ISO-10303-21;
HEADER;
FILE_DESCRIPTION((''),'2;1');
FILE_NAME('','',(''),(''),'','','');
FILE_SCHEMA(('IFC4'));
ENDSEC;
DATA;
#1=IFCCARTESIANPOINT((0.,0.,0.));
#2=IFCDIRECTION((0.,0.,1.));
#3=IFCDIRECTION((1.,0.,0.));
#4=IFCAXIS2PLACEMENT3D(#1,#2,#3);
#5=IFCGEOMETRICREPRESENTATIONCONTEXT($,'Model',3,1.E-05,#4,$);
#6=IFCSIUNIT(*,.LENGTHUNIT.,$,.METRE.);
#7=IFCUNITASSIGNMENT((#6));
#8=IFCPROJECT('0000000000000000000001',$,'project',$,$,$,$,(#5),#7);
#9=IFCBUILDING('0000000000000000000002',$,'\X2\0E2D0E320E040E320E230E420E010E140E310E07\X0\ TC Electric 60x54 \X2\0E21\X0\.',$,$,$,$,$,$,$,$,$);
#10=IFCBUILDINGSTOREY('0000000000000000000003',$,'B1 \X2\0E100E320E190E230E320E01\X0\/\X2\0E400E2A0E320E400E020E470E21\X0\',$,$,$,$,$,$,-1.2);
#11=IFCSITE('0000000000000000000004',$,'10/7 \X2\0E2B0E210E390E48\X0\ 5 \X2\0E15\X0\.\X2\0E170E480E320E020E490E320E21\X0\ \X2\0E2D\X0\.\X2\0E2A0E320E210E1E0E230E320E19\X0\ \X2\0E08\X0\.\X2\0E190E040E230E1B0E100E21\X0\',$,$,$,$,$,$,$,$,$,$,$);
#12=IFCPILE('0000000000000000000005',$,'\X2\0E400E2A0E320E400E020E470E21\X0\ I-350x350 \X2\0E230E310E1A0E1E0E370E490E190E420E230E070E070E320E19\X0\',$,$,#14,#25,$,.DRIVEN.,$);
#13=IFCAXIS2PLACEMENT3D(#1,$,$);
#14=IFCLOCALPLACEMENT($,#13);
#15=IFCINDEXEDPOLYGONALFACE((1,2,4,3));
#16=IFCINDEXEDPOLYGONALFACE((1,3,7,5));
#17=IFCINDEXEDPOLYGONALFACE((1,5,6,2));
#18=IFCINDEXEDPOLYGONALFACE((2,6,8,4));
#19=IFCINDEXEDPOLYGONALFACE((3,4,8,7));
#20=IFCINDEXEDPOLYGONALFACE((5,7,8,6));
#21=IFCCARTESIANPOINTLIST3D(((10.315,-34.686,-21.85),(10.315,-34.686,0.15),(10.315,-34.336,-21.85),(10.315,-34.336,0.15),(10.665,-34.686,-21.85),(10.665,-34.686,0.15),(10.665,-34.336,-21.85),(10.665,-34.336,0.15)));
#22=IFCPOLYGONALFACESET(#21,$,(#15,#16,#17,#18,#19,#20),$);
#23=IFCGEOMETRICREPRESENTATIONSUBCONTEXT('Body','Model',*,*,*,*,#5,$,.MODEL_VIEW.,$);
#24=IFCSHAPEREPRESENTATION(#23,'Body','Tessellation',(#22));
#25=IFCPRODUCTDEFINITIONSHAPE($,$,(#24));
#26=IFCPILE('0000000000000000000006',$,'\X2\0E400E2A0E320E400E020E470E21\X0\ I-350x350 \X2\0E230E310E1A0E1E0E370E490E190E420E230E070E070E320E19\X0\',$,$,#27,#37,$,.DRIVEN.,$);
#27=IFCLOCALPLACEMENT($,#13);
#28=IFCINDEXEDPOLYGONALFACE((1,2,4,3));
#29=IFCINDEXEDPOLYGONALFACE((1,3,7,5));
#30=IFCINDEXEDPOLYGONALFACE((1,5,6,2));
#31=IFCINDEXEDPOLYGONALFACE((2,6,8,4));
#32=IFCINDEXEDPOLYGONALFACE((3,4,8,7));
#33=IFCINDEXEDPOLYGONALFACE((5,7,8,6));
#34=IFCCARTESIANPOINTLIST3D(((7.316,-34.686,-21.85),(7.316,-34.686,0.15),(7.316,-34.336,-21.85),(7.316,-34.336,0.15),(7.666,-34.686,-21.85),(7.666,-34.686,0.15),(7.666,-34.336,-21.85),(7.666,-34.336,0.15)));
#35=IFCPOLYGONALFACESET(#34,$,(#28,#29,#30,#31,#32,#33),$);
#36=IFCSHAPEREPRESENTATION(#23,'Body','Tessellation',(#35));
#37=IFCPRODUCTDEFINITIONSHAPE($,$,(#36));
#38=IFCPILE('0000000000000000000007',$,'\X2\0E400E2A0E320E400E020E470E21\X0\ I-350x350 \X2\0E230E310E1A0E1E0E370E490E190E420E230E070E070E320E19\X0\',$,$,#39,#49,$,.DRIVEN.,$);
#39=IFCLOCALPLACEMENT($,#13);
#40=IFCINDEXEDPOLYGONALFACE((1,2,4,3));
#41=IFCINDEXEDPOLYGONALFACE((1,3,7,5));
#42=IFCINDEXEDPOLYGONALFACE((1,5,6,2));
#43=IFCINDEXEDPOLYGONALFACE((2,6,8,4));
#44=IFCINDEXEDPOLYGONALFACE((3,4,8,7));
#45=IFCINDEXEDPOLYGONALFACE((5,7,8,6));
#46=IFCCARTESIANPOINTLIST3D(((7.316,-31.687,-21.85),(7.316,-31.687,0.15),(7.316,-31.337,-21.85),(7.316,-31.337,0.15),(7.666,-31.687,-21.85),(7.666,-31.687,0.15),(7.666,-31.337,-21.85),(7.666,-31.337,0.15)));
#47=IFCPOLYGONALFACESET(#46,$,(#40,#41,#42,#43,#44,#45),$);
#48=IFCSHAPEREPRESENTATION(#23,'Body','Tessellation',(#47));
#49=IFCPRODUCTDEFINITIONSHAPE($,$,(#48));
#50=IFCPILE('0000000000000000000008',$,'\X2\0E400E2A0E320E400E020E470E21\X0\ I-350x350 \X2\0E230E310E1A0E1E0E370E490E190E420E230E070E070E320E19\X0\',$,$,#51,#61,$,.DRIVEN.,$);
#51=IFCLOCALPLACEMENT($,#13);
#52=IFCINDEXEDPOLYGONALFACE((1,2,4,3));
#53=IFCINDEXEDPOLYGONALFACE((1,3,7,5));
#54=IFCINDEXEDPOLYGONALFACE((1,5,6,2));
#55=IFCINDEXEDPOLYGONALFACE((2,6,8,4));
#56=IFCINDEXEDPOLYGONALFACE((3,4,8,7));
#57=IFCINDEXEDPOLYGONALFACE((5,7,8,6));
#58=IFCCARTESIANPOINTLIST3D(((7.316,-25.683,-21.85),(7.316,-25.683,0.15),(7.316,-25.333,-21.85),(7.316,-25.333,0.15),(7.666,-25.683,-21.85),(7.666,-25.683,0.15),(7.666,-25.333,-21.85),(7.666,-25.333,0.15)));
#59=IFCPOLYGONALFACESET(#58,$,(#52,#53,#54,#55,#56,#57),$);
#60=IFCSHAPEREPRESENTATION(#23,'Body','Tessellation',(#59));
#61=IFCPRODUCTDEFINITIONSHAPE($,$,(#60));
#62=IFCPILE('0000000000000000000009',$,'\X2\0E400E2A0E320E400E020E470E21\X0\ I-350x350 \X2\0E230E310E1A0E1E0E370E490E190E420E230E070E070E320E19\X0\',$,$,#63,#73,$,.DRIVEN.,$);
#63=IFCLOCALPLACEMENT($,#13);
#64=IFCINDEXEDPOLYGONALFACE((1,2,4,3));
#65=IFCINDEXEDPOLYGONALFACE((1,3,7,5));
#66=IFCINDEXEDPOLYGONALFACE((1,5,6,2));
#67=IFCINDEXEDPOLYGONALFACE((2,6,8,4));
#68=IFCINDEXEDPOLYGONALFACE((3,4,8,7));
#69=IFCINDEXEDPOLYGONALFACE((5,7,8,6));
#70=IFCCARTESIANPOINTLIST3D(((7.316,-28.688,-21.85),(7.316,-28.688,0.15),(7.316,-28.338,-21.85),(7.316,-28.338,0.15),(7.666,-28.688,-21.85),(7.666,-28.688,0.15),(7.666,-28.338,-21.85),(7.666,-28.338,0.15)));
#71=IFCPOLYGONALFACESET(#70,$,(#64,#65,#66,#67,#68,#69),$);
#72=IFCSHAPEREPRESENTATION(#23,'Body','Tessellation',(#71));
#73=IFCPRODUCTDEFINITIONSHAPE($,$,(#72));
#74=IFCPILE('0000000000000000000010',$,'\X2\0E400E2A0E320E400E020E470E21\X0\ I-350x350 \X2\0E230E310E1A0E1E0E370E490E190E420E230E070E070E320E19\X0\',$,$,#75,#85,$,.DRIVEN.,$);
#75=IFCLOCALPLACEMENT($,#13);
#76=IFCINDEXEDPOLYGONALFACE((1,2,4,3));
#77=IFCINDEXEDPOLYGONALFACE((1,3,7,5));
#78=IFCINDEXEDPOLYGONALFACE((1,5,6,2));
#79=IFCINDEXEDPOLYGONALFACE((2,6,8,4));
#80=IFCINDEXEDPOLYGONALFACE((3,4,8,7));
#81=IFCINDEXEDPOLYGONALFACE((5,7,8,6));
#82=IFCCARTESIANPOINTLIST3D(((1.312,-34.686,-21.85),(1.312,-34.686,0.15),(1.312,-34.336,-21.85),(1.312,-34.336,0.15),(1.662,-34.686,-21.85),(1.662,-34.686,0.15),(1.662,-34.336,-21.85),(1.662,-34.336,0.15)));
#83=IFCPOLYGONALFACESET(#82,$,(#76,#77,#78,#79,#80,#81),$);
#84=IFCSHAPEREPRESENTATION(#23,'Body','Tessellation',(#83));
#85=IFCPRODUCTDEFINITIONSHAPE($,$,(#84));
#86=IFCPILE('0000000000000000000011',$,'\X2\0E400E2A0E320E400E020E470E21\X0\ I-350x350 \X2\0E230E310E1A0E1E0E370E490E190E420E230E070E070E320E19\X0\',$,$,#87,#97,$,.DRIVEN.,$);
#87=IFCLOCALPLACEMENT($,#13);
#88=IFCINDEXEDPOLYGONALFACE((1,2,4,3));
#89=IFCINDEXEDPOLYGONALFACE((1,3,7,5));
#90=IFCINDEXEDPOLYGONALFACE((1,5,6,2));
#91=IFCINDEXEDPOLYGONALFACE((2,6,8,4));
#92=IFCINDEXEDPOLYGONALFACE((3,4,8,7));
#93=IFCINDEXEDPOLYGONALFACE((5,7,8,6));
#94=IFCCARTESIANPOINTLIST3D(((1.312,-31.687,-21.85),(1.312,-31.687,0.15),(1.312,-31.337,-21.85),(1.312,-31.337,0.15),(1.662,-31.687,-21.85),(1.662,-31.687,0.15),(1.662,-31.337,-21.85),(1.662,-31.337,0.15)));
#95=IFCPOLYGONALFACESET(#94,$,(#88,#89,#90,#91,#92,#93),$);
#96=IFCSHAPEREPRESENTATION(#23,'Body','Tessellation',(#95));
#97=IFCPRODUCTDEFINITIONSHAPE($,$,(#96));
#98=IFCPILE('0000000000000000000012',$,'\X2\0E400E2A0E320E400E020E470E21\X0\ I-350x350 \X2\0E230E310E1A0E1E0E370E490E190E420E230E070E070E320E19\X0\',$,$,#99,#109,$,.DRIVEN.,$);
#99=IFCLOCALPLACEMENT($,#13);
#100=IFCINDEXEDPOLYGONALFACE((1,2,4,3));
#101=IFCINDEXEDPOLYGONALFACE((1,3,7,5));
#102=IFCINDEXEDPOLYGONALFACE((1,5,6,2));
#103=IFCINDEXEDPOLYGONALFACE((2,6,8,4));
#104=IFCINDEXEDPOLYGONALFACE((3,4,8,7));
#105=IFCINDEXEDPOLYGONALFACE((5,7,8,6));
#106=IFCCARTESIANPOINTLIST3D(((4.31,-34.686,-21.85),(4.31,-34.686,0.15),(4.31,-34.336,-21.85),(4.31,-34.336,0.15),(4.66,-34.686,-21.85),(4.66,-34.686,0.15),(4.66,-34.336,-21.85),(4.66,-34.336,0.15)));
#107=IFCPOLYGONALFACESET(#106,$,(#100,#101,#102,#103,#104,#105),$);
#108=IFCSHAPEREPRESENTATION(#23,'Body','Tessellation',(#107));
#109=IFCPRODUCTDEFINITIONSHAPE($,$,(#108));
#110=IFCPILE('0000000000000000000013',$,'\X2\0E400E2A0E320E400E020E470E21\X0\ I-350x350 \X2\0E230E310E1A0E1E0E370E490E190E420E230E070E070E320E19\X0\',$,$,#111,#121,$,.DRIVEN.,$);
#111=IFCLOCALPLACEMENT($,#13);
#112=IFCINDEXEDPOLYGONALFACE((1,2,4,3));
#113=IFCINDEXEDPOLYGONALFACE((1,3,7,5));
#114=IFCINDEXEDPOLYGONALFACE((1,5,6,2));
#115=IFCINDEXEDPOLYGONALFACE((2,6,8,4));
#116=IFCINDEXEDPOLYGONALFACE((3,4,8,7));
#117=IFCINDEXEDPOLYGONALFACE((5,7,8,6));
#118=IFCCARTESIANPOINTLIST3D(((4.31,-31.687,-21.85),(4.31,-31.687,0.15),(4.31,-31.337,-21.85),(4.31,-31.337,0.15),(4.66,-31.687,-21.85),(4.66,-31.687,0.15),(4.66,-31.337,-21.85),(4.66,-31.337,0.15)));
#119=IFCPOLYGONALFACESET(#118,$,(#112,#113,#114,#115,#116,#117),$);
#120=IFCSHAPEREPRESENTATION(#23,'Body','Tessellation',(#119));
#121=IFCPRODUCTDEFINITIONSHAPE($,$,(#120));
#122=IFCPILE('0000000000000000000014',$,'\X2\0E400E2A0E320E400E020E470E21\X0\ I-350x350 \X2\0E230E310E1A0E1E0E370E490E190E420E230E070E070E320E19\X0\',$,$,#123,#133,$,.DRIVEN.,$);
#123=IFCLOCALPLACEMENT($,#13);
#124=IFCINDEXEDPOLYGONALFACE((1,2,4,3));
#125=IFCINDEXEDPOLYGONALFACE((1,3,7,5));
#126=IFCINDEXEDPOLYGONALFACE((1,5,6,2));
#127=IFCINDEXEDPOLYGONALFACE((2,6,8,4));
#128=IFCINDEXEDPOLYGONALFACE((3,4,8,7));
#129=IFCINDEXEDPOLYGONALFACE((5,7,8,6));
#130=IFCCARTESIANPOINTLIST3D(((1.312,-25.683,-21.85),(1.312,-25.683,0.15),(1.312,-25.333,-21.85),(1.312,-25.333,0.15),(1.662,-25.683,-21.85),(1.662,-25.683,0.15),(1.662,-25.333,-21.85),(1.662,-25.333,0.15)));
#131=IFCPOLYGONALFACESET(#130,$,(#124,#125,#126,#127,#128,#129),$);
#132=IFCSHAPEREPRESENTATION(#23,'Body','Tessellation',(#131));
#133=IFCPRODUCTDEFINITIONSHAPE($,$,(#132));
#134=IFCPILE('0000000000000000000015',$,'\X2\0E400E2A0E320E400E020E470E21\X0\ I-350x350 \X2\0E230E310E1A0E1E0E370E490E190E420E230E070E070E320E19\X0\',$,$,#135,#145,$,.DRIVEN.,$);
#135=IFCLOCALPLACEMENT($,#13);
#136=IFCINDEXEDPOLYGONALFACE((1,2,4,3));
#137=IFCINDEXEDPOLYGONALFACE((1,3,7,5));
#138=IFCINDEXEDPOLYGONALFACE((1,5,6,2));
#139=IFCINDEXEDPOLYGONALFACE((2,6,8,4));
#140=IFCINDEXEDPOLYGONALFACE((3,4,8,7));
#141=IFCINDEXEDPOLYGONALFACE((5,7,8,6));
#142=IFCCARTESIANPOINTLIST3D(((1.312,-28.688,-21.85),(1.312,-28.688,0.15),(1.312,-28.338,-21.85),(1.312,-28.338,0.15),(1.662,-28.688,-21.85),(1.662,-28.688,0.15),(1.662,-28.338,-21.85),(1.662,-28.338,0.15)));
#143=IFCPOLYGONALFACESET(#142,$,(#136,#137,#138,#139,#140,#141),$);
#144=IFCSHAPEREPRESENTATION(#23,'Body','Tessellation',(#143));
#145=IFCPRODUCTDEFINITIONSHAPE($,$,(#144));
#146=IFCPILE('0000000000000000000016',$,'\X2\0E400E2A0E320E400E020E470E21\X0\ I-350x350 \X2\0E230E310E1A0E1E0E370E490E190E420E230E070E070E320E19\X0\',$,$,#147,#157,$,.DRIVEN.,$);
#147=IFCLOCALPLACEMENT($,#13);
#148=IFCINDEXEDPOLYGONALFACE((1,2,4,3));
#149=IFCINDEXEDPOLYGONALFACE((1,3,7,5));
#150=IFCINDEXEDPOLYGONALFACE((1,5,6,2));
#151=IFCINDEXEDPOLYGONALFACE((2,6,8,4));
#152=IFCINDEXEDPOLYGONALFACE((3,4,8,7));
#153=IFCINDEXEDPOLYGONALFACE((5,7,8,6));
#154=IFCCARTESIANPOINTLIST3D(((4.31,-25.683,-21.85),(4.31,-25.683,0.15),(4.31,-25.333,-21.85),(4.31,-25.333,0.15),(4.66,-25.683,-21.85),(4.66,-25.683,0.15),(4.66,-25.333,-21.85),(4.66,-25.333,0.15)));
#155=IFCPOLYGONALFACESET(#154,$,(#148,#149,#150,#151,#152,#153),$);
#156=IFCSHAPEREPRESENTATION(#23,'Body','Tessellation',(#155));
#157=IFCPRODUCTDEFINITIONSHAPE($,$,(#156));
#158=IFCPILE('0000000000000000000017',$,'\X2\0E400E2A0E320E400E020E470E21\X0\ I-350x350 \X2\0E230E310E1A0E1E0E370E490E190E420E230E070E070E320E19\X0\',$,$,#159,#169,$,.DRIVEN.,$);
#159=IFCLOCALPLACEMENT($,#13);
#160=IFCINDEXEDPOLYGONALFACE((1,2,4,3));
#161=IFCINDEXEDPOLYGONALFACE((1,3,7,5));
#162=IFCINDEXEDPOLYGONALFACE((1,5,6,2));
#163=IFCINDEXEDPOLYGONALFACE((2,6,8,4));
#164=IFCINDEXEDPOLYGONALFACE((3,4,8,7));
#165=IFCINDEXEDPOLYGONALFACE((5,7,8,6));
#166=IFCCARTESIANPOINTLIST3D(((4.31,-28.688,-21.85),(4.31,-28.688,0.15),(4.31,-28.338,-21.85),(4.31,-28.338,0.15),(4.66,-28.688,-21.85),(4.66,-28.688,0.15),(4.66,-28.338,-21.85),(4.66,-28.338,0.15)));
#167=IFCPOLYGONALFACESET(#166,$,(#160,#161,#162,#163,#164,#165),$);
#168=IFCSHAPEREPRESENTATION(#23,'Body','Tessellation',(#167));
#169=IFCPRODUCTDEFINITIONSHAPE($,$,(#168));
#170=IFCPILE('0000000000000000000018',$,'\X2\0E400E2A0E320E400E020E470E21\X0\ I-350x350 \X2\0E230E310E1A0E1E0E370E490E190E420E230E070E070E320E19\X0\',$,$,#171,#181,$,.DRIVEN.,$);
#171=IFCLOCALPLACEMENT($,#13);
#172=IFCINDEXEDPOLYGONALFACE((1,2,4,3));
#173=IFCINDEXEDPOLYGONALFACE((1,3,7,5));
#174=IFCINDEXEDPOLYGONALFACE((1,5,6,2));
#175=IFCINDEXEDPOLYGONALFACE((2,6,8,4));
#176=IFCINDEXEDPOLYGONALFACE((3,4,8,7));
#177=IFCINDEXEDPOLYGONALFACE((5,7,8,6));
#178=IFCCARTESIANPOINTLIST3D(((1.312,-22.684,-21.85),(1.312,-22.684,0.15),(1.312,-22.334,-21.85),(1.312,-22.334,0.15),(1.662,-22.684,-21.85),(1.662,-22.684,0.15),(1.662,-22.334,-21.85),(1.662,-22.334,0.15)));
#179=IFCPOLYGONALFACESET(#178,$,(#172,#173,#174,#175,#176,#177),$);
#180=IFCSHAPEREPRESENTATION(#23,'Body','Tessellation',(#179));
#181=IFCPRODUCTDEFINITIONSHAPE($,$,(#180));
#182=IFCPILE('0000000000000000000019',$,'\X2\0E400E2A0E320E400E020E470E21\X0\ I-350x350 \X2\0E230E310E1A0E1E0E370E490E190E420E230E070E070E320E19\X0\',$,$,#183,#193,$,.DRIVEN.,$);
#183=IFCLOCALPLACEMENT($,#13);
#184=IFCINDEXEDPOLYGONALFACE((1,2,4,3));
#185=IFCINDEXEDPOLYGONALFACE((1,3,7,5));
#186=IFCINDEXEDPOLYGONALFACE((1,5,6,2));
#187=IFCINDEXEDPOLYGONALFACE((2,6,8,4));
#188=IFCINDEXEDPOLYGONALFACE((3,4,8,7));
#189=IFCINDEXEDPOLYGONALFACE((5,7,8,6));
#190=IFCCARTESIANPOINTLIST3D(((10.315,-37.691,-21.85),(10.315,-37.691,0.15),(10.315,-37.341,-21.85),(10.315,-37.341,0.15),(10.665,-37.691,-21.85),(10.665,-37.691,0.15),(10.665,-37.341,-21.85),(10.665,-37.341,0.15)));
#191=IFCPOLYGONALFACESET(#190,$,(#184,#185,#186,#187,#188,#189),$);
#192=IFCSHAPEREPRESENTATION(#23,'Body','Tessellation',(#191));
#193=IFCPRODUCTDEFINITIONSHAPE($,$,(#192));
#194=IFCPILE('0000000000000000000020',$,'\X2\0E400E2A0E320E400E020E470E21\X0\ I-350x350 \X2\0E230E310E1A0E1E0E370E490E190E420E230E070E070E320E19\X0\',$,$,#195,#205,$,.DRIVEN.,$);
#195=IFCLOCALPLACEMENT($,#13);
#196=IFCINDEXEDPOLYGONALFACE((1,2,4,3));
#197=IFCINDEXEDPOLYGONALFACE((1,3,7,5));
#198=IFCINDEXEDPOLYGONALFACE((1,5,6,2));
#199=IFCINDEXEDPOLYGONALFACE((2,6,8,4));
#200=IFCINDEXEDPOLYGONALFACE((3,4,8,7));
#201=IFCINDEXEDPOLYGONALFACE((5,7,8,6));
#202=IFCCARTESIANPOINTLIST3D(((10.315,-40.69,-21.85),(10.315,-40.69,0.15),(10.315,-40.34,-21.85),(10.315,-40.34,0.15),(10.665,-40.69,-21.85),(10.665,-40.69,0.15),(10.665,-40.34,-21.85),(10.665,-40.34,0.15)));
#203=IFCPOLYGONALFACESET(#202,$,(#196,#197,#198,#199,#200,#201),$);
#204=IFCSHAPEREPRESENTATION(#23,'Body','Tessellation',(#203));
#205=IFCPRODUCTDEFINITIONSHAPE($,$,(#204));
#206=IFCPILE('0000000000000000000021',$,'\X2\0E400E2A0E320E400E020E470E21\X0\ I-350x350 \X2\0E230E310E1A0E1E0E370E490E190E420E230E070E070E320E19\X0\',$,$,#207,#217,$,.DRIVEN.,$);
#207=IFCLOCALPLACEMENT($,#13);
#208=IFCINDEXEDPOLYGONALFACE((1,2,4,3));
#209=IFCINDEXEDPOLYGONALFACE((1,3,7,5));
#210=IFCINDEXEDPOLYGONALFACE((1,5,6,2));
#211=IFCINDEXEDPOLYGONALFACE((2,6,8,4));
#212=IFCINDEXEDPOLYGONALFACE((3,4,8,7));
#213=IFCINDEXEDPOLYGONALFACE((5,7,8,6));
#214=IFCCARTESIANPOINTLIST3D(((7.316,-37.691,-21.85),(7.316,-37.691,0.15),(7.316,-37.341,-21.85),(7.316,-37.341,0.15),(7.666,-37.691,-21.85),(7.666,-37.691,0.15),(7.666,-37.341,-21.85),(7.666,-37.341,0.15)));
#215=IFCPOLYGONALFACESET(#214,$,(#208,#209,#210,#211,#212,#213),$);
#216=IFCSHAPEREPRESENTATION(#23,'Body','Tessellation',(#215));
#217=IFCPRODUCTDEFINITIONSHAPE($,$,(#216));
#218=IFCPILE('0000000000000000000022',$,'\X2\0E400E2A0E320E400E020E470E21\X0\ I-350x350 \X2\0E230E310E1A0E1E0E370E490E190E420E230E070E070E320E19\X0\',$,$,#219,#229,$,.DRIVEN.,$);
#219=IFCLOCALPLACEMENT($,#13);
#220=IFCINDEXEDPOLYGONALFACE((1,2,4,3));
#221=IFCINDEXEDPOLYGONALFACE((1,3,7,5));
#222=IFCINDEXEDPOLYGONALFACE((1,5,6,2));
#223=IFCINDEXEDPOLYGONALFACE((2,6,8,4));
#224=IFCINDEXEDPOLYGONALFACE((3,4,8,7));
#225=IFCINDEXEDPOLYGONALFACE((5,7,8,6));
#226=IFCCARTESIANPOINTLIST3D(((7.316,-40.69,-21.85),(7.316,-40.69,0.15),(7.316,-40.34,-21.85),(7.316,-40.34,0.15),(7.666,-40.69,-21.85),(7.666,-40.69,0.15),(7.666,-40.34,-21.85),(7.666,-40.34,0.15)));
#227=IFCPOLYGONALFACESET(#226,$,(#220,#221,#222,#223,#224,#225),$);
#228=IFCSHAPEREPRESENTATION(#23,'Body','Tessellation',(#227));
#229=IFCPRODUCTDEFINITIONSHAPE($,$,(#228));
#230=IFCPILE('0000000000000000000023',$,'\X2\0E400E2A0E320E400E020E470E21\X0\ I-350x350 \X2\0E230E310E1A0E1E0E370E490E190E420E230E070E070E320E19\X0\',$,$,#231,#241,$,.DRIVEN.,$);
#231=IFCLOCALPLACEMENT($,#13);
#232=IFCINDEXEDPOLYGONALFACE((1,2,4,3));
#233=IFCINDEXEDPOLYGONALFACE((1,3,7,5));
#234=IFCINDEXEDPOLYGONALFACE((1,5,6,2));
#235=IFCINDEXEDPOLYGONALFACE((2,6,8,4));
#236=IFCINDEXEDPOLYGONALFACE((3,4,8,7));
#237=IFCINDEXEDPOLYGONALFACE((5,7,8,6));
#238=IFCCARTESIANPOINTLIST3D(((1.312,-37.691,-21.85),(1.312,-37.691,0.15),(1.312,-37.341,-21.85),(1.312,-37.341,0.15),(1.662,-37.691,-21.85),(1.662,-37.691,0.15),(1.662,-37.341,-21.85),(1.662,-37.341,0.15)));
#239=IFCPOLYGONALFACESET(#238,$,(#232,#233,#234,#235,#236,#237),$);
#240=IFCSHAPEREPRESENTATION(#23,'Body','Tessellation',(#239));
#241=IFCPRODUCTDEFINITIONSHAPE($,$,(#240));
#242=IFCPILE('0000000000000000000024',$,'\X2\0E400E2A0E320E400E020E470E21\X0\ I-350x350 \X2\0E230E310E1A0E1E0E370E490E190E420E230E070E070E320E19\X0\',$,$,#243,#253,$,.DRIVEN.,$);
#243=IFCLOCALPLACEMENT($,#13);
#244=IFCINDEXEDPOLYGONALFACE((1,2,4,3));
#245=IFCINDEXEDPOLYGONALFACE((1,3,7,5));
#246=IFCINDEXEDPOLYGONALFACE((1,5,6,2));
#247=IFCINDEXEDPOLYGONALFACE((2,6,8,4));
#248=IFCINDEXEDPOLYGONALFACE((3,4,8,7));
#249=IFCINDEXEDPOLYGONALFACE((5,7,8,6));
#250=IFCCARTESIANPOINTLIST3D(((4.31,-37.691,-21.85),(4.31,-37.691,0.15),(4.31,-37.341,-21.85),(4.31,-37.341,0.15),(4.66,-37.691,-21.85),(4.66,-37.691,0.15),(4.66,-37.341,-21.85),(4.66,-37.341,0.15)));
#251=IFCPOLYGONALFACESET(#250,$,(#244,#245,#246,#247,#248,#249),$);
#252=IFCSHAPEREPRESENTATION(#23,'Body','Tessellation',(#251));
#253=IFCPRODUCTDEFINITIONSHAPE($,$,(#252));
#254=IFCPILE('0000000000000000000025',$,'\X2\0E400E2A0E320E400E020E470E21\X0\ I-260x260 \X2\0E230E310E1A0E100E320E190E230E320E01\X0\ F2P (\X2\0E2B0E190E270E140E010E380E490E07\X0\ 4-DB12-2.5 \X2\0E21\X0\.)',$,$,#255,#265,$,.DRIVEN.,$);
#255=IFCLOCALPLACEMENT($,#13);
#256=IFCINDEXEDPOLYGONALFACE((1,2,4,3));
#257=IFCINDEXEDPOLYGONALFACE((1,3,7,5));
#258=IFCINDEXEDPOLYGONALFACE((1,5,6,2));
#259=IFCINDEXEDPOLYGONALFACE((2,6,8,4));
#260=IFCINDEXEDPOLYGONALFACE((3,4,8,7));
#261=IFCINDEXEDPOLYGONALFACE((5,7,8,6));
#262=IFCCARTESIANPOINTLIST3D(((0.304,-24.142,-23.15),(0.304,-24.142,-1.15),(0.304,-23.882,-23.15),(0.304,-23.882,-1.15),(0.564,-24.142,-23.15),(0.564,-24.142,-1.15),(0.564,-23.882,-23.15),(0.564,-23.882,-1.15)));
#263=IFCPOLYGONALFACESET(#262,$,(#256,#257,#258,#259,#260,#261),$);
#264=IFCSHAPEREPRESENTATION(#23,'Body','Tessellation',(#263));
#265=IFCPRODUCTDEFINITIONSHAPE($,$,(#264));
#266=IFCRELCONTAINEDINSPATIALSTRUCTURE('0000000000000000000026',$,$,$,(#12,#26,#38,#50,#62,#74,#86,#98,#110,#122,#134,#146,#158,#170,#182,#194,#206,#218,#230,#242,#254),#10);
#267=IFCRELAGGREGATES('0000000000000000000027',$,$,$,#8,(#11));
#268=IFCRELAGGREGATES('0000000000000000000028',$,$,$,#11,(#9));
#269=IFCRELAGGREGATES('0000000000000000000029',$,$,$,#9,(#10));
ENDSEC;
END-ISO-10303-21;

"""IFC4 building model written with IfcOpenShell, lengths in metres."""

from ifc_helpers import new_model, si_unit, frame, origin, origin_with_axes, origin_2d, place, context, subcontext, project, spatial, rectangle, extrude, element, save


model = new_model("IFC4")

# Units and contexts
model_context = context("Model", 3, precision=1e-05, world=origin_with_axes())
body_context = subcontext(model_context, "Body", "Model", "MODEL_VIEW")
ifc_project = project(units=[si_unit("LENGTHUNIT", "METRE")], contexts=[model_context])

# Site, building, storey
site = spatial("IfcSite", under=ifc_project, Name="10/7 หมู่ 5 ต.ท่าข้าม อ.สามพราน จ.นครปฐม")
building = spatial("IfcBuilding", under=site, Name="อาคารโกดัง TC Electric 60x54 ม.")
storey = spatial("IfcBuildingStorey", under=building, Name="B1 ฐานราก/เสาเข็ม", Elevation=-1.2)

# Piles
for number, where, z_axis, x_axis, name in (
    (1, (10.49, -34.511, -21.85), (0.0, 0.0, 1.0), (1.0, 0.0, 0.0), "เสาเข็ม I-350x350 รับพื้นโรงงาน"),
    (2, (7.491, -34.511, -21.85), (0.0, 0.0, 1.0), (1.0, 0.0, 0.0), "เสาเข็ม I-350x350 รับพื้นโรงงาน"),
    (3, (7.491, -31.512, -21.85), (0.0, 0.0, 1.0), (1.0, 0.0, 0.0), "เสาเข็ม I-350x350 รับพื้นโรงงาน"),
    (4, (7.491, -25.508, -21.85), (0.0, 0.0, 1.0), (1.0, 0.0, 0.0), "เสาเข็ม I-350x350 รับพื้นโรงงาน"),
    (5, (7.491, -28.513, -21.85), (0.0, 0.0, 1.0), (1.0, 0.0, 0.0), "เสาเข็ม I-350x350 รับพื้นโรงงาน"),
    (6, (1.487, -34.511, -21.85), (0.0, 0.0, 1.0), (1.0, 0.0, 0.0), "เสาเข็ม I-350x350 รับพื้นโรงงาน"),
    (7, (1.487, -31.512, -21.85), (0.0, 0.0, 1.0), (1.0, 0.0, 0.0), "เสาเข็ม I-350x350 รับพื้นโรงงาน"),
    (8, (4.485, -34.511, -21.85), (0.0, 0.0, 1.0), (1.0, 0.0, 0.0), "เสาเข็ม I-350x350 รับพื้นโรงงาน"),
    (9, (4.485, -31.512, -21.85), (0.0, 0.0, 1.0), (1.0, 0.0, 0.0), "เสาเข็ม I-350x350 รับพื้นโรงงาน"),
    (10, (1.487, -25.508, -21.85), (0.0, 0.0, 1.0), (1.0, 0.0, 0.0), "เสาเข็ม I-350x350 รับพื้นโรงงาน"),
    (11, (1.487, -28.513, -21.85), (0.0, 0.0, 1.0), (1.0, 0.0, 0.0), "เสาเข็ม I-350x350 รับพื้นโรงงาน"),
    (12, (4.485, -25.508, -21.85), (0.0, 0.0, 1.0), (1.0, 0.0, 0.0), "เสาเข็ม I-350x350 รับพื้นโรงงาน"),
    (13, (4.485, -28.513, -21.85), (0.0, 0.0, 1.0), (1.0, 0.0, 0.0), "เสาเข็ม I-350x350 รับพื้นโรงงาน"),
    (14, (1.487, -22.509, -21.85), (0.0, 0.0, 1.0), (1.0, 0.0, 0.0), "เสาเข็ม I-350x350 รับพื้นโรงงาน"),
    (15, (10.49, -37.516, -21.85), (0.0, 0.0, 1.0), (1.0, 0.0, 0.0), "เสาเข็ม I-350x350 รับพื้นโรงงาน"),
    (16, (10.49, -40.515, -21.85), (0.0, 0.0, 1.0), (1.0, 0.0, 0.0), "เสาเข็ม I-350x350 รับพื้นโรงงาน"),
    (17, (7.491, -37.516, -21.85), (0.0, 0.0, 1.0), (1.0, 0.0, 0.0), "เสาเข็ม I-350x350 รับพื้นโรงงาน"),
    (18, (7.491, -40.515, -21.85), (0.0, 0.0, 1.0), (1.0, 0.0, 0.0), "เสาเข็ม I-350x350 รับพื้นโรงงาน"),
    (19, (1.487, -37.516, -21.85), (0.0, 0.0, 1.0), (1.0, 0.0, 0.0), "เสาเข็ม I-350x350 รับพื้นโรงงาน"),
    (20, (4.485, -37.516, -21.85), (0.0, 0.0, 1.0), (1.0, 0.0, 0.0), "เสาเข็ม I-350x350 รับพื้นโรงงาน"),
):
    element("IfcPile", number, at=place(None, frame(where, z_axis=z_axis, x_axis=x_axis)), inside=storey, Name=name, PredefinedType="DRIVEN", context=body_context, shape_type="SweptSolid", body=[
        extrude(rectangle(XDim=0.35, YDim=0.35, at=origin_2d()), origin(), (0.0, 0.0, 1.0), 22.0),
    ])
for number, where, z_axis, x_axis, name in (
    (21, (0.434, -24.012, -23.15), (0.0, 0.0, 1.0), (1.0, 0.0, 0.0), "เสาเข็ม I-260x260 รับฐานราก F2P (หนวดกุ้ง 4-DB12-2.5 ม.)"),
):
    element("IfcPile", number, at=place(None, frame(where, z_axis=z_axis, x_axis=x_axis)), inside=storey, Name=name, PredefinedType="DRIVEN", context=body_context, shape_type="SweptSolid", body=[
        extrude(rectangle(XDim=0.26, YDim=0.26, at=origin_2d()), origin(), (0.0, 0.0, 1.0), 22.0),
    ])

save(model, "model.ifc")
